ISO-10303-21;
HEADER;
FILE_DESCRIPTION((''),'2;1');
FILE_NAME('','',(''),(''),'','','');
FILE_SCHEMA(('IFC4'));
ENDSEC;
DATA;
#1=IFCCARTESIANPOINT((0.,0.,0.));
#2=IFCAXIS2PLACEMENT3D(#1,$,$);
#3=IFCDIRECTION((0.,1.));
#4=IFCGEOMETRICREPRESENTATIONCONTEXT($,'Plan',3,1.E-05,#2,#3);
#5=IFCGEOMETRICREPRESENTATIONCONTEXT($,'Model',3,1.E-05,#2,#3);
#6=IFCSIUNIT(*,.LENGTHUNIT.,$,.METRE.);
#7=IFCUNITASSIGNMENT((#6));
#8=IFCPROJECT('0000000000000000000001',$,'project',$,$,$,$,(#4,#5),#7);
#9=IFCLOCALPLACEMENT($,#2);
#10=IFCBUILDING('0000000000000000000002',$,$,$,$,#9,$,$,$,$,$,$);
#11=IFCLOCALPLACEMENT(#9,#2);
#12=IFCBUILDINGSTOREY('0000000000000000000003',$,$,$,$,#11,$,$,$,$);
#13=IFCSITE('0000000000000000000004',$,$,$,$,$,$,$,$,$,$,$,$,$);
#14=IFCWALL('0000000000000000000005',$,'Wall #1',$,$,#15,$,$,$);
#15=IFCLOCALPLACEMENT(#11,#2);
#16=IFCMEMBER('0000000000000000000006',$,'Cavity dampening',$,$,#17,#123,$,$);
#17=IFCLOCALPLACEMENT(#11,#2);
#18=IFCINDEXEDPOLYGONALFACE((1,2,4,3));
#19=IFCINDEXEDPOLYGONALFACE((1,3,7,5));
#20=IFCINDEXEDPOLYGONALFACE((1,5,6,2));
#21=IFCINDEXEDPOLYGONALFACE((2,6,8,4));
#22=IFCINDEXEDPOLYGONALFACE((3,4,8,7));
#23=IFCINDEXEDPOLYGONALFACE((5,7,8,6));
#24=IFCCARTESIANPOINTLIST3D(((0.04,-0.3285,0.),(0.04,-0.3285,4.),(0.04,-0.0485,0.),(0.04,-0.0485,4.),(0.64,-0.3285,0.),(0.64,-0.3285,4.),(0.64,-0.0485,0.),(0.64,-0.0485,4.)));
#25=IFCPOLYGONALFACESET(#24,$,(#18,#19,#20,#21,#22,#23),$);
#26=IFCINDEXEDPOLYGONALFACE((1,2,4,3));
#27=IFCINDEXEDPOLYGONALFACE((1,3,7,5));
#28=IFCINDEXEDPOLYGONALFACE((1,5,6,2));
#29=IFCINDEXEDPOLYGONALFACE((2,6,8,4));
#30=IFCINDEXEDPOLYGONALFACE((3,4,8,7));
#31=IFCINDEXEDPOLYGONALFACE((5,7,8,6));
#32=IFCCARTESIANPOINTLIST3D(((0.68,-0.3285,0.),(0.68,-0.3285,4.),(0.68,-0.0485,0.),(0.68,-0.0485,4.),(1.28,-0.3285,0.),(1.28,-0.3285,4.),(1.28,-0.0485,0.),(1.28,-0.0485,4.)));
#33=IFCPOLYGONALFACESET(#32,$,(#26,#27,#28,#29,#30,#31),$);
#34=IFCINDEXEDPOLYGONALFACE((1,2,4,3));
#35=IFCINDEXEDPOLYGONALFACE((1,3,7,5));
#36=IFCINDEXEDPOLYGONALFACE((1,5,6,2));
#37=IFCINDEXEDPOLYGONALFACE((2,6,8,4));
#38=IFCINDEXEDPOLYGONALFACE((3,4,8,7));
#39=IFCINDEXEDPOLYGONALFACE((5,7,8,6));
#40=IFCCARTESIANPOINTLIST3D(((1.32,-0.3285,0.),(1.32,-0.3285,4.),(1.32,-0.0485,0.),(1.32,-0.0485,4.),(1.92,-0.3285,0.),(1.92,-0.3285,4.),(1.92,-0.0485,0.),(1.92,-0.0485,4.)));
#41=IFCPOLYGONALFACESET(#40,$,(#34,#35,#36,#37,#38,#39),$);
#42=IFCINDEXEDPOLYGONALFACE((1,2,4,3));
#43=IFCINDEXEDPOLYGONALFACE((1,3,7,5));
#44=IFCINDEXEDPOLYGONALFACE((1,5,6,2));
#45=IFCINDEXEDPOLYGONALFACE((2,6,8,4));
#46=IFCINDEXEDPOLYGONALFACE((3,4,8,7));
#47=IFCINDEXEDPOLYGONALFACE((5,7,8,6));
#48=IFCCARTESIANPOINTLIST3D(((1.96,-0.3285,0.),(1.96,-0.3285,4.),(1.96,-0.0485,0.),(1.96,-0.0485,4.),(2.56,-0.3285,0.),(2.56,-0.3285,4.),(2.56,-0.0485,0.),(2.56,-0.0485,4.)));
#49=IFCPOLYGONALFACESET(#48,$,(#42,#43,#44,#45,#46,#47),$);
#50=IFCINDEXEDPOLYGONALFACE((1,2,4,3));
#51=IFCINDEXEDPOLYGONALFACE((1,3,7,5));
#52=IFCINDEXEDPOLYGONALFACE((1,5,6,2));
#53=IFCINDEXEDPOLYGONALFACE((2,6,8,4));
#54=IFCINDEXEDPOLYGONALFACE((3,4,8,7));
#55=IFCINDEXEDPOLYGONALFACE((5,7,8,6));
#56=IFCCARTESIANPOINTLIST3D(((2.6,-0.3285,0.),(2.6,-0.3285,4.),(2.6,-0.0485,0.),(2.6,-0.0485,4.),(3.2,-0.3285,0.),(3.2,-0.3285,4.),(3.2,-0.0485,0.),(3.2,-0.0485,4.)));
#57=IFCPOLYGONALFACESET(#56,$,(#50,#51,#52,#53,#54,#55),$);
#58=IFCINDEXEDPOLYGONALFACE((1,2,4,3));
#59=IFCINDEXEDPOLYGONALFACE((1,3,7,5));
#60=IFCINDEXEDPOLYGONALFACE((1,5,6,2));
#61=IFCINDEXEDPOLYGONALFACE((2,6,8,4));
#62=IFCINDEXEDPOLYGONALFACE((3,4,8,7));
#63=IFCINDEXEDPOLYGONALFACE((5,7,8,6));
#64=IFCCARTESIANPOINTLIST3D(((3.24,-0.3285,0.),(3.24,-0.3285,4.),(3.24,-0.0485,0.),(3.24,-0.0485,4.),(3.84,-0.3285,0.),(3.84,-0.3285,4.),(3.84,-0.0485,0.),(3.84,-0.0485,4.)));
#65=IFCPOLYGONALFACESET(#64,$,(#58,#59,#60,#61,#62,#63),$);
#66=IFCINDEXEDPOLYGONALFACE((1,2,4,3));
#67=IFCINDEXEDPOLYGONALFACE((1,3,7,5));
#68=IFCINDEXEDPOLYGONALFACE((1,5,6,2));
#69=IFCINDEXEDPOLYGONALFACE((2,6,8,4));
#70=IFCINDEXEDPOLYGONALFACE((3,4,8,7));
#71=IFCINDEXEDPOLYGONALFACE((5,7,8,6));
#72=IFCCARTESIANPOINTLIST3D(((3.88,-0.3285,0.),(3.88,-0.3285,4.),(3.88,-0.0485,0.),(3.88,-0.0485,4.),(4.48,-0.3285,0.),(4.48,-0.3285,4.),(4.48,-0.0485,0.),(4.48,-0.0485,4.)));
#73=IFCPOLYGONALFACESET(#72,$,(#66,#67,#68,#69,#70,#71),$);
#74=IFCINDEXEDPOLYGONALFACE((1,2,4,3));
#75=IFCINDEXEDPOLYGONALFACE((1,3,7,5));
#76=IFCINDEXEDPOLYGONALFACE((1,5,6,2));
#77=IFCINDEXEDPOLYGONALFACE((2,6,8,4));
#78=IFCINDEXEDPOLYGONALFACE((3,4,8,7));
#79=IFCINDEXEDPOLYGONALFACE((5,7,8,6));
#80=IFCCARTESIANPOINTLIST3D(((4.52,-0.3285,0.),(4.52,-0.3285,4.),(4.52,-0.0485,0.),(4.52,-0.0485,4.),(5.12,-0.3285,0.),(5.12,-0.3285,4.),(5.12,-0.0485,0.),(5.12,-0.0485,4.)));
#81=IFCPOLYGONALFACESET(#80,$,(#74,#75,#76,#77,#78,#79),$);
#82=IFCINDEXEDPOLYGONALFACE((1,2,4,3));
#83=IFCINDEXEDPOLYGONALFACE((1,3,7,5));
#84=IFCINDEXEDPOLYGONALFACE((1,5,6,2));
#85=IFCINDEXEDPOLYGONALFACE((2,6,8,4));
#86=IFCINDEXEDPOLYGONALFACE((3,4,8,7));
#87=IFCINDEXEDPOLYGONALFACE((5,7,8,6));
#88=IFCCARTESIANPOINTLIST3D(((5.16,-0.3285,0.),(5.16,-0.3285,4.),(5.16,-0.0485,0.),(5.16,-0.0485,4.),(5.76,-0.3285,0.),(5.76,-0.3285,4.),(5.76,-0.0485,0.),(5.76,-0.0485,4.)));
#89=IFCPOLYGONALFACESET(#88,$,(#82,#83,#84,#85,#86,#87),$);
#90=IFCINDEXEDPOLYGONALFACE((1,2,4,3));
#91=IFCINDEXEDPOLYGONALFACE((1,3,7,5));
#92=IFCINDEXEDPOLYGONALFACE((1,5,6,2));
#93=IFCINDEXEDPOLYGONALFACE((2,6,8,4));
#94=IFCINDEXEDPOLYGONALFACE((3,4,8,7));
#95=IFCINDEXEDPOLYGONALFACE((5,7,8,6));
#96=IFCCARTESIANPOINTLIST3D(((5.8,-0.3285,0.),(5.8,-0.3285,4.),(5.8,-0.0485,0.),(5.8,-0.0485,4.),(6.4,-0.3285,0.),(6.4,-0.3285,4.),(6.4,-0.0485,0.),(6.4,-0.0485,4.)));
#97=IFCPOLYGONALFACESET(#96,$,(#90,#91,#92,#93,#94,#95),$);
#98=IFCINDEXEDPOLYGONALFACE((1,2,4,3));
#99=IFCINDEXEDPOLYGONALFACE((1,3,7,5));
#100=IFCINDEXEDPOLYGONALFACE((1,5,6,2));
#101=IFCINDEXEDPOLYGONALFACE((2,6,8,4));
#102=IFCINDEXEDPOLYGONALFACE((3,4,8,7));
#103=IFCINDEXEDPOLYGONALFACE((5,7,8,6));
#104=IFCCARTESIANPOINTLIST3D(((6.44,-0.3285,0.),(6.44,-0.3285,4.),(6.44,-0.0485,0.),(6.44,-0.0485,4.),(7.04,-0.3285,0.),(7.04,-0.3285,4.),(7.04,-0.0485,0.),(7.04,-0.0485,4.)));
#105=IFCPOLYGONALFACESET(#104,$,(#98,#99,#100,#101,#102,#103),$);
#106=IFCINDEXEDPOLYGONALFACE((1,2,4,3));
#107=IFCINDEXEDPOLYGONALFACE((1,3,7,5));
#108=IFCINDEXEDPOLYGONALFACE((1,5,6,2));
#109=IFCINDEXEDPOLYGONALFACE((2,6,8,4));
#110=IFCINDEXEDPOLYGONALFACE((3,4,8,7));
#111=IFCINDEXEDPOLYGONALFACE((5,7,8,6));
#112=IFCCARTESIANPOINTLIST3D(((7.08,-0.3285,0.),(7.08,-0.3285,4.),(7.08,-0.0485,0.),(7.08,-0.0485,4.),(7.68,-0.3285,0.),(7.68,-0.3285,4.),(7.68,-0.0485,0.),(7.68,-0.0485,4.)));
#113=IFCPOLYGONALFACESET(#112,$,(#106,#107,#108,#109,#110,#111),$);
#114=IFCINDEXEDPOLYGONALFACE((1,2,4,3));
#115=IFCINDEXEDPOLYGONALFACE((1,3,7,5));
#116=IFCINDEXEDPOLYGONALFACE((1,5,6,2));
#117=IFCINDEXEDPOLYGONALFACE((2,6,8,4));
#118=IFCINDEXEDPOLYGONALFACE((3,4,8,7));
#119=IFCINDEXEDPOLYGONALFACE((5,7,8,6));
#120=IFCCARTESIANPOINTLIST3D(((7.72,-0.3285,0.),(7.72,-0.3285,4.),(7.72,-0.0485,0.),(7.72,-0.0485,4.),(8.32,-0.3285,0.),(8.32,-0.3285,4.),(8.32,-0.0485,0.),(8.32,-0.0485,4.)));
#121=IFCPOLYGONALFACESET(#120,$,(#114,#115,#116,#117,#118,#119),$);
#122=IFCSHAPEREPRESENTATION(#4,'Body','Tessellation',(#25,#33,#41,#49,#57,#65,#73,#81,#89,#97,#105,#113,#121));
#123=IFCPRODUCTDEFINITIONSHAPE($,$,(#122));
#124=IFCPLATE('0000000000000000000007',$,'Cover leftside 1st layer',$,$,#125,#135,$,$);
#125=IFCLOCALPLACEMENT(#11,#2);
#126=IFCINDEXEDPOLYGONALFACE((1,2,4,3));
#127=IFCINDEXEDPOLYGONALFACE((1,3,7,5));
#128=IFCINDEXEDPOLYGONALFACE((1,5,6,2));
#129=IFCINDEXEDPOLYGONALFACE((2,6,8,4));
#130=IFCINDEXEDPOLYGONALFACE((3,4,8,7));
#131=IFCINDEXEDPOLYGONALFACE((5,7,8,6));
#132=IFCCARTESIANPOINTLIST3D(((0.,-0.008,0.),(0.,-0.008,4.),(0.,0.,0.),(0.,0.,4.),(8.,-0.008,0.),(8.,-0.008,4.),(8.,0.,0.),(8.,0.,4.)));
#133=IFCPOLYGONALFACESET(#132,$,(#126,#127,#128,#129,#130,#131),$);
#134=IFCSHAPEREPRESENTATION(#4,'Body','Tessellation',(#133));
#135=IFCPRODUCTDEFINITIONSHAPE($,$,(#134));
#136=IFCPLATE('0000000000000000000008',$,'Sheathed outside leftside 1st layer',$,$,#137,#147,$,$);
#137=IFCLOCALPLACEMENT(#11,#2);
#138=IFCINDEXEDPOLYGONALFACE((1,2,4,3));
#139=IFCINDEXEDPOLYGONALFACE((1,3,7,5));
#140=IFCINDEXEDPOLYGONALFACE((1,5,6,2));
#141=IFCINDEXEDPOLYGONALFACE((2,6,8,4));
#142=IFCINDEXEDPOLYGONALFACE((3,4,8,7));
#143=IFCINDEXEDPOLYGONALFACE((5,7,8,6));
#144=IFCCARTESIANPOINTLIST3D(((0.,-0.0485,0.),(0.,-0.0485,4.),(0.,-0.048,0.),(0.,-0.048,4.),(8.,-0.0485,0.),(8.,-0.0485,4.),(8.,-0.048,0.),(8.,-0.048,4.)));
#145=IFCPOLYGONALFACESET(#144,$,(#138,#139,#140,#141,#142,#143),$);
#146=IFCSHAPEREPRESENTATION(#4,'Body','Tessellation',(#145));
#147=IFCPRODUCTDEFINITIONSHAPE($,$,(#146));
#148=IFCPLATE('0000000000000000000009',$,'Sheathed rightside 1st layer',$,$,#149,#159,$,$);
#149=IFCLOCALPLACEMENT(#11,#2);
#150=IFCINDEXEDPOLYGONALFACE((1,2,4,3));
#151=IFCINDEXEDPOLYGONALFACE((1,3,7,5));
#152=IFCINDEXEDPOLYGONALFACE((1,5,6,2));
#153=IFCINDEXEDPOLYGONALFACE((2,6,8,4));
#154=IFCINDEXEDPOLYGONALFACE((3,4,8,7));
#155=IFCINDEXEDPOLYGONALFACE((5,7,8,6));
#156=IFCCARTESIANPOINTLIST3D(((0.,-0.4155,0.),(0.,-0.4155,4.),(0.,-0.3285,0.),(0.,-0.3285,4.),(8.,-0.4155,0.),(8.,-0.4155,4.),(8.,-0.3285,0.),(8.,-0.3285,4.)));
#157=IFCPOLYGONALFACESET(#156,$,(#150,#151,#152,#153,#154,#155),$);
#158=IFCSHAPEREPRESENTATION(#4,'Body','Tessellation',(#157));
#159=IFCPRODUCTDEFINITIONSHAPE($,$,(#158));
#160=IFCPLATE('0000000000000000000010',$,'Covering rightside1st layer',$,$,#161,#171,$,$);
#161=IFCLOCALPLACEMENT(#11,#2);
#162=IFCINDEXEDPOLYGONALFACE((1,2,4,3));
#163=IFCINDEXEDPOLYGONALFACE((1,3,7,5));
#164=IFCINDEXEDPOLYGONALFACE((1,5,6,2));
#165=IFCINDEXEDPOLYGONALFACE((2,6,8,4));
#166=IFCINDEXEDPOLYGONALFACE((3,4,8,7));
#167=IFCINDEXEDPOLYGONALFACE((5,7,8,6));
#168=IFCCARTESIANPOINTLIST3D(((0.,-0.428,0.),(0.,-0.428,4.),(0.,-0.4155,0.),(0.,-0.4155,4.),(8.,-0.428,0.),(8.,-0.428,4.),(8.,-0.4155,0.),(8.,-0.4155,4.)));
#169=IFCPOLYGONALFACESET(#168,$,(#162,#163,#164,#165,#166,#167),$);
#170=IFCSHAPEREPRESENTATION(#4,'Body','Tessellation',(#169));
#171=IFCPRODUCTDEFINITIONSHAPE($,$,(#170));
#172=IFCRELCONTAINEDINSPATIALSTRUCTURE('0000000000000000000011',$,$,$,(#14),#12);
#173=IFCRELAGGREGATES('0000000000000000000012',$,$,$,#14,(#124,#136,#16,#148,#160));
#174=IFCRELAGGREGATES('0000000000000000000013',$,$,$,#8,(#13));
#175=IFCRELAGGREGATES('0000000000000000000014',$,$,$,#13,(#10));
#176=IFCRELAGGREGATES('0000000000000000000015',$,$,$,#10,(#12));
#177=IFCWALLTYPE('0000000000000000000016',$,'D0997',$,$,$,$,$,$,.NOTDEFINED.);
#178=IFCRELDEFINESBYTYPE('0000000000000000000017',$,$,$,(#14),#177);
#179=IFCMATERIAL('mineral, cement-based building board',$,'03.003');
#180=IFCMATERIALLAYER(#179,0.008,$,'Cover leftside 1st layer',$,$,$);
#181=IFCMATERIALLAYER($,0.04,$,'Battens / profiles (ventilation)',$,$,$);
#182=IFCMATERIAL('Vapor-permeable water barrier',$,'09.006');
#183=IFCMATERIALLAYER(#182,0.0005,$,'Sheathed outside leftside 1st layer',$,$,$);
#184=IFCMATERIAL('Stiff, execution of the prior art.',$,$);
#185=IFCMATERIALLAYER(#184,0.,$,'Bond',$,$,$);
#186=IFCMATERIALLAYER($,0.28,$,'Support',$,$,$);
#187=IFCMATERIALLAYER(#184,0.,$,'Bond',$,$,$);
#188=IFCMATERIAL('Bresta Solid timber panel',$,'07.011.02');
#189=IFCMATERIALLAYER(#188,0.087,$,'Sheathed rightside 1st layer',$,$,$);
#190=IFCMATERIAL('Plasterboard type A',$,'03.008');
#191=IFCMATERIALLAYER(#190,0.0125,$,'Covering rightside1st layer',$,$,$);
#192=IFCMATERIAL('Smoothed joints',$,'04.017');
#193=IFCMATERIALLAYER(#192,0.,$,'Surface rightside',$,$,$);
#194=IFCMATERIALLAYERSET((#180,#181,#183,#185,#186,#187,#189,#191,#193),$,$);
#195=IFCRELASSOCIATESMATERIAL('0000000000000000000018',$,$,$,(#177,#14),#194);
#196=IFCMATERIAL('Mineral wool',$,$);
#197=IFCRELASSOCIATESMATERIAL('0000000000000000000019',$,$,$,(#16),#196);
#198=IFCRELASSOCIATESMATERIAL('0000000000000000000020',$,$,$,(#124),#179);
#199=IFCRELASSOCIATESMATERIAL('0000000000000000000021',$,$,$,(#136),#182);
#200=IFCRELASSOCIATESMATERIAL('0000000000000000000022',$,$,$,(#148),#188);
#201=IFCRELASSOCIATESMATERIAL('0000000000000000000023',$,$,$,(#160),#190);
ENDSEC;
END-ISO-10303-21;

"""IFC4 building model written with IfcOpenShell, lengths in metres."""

from ifc_helpers import new_model, si_unit, direction, frame, frame_2d, origin, origin_with_axes, place, context, project, spatial, rectangle, extrude, material, layer, layer_set, type_object, element, aggregate, save


model = new_model("IFC4")

# Units and contexts
plan_context = context("Plan", 3, precision=1e-05, world=origin(), true_north=direction((0.0, 1.0)))
model_context = context("Model", 3, precision=1e-05, world=origin(), true_north=direction((0.0, 1.0)))
ifc_project = project(units=[si_unit("LENGTHUNIT", "METRE")], contexts=[plan_context, model_context])

# Site, building, storey
site = spatial("IfcSite", under=ifc_project)
building_placement = place(None, origin())
building = spatial("IfcBuilding", under=site, at=building_placement)
storey_placement = place(building_placement, origin())
storey = spatial("IfcBuildingStorey", under=building, at=storey_placement)

# Wall, member, plates
ifc_material_1 = material(Name="mineral, cement-based building board", Category="03.003")
ifc_layer_1 = layer(ifc_material_1, 0.008, Name="Cover leftside 1st layer")
ifc_layer_2 = layer(None, 0.04, Name="Battens / profiles (ventilation)")
ifc_material_2 = material(Name="Vapor-permeable water barrier", Category="09.006")
ifc_layer_3 = layer(ifc_material_2, 0.0005, Name="Sheathed outside leftside 1st layer")
ifc_material_3 = material(Name="Stiff, execution of the prior art.")
ifc_layer_4 = layer(ifc_material_3, 0.0, Name="Bond")
ifc_layer_5 = layer(None, 0.28, Name="Support")
ifc_layer_6 = layer(ifc_material_3, 0.0, Name="Bond")
ifc_material_4 = material(Name="Bresta Solid timber panel", Category="07.011.02")
ifc_layer_7 = layer(ifc_material_4, 0.087, Name="Sheathed rightside 1st layer")
ifc_material_5 = material(Name="Plasterboard type A", Category="03.008")
ifc_layer_8 = layer(ifc_material_5, 0.0125, Name="Covering rightside1st layer")
ifc_material_6 = material(Name="Smoothed joints", Category="04.017")
ifc_layer_9 = layer(ifc_material_6, 0.0, Name="Surface rightside")
ifc_layer_set = layer_set([ifc_layer_1, ifc_layer_2, ifc_layer_3, ifc_layer_4, ifc_layer_5, ifc_layer_6, ifc_layer_7, ifc_layer_8, ifc_layer_9])
wall_type = type_object("IfcWallType", Name="D0997", PredefinedType="NOTDEFINED", material=ifc_layer_set)
wall_placement = place(None, frame((0.0, 0.0, 0.0), z_axis=(0.0, -1.0, 0.0), x_axis=(1.0, 0.0, 0.0)))
wall = element("IfcWall", 1, at=wall_placement, inside=storey, type_object=wall_type, material=ifc_layer_set, Name="Wall #1")
ifc_material_7 = material(Name="Mineral wool")
member_1_placement = place(wall_placement, origin())
member_1 = element("IfcMember", 2, at=member_1_placement, material=ifc_material_7, Name="Cavity dampening", context=plan_context, shape_type="SweptSolid", body=[
    extrude(rectangle(XDim=0.6, YDim=0.28, at=frame_2d((0.3, 0.14), x_axis=(1.0, 0.0))), frame((0.04, 4.0, 0.0485), z_axis=(0.0, -1.0, 0.0), x_axis=(1.0, 0.0, 0.0)), (0.0, 0.0, 1.0), 4.0),
    extrude(rectangle(XDim=0.6, YDim=0.28, at=frame_2d((0.3, 0.14), x_axis=(1.0, 0.0))), frame((0.68, 4.0, 0.0485), z_axis=(0.0, -1.0, 0.0), x_axis=(1.0, 0.0, 0.0)), (0.0, 0.0, 1.0), 4.0),
    extrude(rectangle(XDim=0.6, YDim=0.28, at=frame_2d((0.3, 0.14), x_axis=(1.0, 0.0))), frame((1.32, 4.0, 0.0485), z_axis=(0.0, -1.0, 0.0), x_axis=(1.0, 0.0, 0.0)), (0.0, 0.0, 1.0), 4.0),
    extrude(rectangle(XDim=0.6, YDim=0.28, at=frame_2d((0.3, 0.14), x_axis=(1.0, 0.0))), frame((1.96, 4.0, 0.0485), z_axis=(0.0, -1.0, 0.0), x_axis=(1.0, 0.0, 0.0)), (0.0, 0.0, 1.0), 4.0),
    extrude(rectangle(XDim=0.6, YDim=0.28, at=frame_2d((0.3, 0.14), x_axis=(1.0, 0.0))), frame((2.6, 4.0, 0.0485), z_axis=(0.0, -1.0, 0.0), x_axis=(1.0, 0.0, 0.0)), (0.0, 0.0, 1.0), 4.0),
    extrude(rectangle(XDim=0.6, YDim=0.28, at=frame_2d((0.3, 0.14), x_axis=(1.0, 0.0))), frame((3.24, 4.0, 0.0485), z_axis=(0.0, -1.0, 0.0), x_axis=(1.0, 0.0, 0.0)), (0.0, 0.0, 1.0), 4.0),
    extrude(rectangle(XDim=0.6, YDim=0.28, at=frame_2d((0.3, 0.14), x_axis=(1.0, 0.0))), frame((3.88, 4.0, 0.0485), z_axis=(0.0, -1.0, 0.0), x_axis=(1.0, 0.0, 0.0)), (0.0, 0.0, 1.0), 4.0),
    extrude(rectangle(XDim=0.6, YDim=0.28, at=frame_2d((0.3, 0.14), x_axis=(1.0, 0.0))), frame((4.52, 4.0, 0.0485), z_axis=(0.0, -1.0, 0.0), x_axis=(1.0, 0.0, 0.0)), (0.0, 0.0, 1.0), 4.0),
    extrude(rectangle(XDim=0.6, YDim=0.28, at=frame_2d((0.3, 0.14), x_axis=(1.0, 0.0))), frame((5.16, 4.0, 0.0485), z_axis=(0.0, -1.0, 0.0), x_axis=(1.0, 0.0, 0.0)), (0.0, 0.0, 1.0), 4.0),
    extrude(rectangle(XDim=0.6, YDim=0.28, at=frame_2d((0.3, 0.14), x_axis=(1.0, 0.0))), frame((5.8, 4.0, 0.0485), z_axis=(0.0, -1.0, 0.0), x_axis=(1.0, 0.0, 0.0)), (0.0, 0.0, 1.0), 4.0),
    extrude(rectangle(XDim=0.6, YDim=0.28, at=frame_2d((0.3, 0.14), x_axis=(1.0, 0.0))), frame((6.44, 4.0, 0.0485), z_axis=(0.0, -1.0, 0.0), x_axis=(1.0, 0.0, 0.0)), (0.0, 0.0, 1.0), 4.0),
    extrude(rectangle(XDim=0.6, YDim=0.28, at=frame_2d((0.3, 0.14), x_axis=(1.0, 0.0))), frame((7.08, 4.0, 0.0485), z_axis=(0.0, -1.0, 0.0), x_axis=(1.0, 0.0, 0.0)), (0.0, 0.0, 1.0), 4.0),
    extrude(rectangle(XDim=0.6, YDim=0.28, at=frame_2d((0.3, 0.14), x_axis=(1.0, 0.0))), frame((7.72, 4.0, 0.0485), z_axis=(0.0, -1.0, 0.0), x_axis=(1.0, 0.0, 0.0)), (0.0, 0.0, 1.0), 4.0),
])
plate_1_placement = place(wall_placement, origin())
plate_1 = element("IfcPlate", 3, at=plate_1_placement, material=ifc_material_1, Name="Cover leftside 1st layer", context=plan_context, shape_type="SweptSolid", body=[
    extrude(rectangle(XDim=8.0, YDim=4.0, at=frame_2d((4.0, 2.0), x_axis=(1.0, 0.0))), origin_with_axes(), (0.0, 0.0, 1.0), 0.008),
])
plate_2_placement = place(wall_placement, origin())
plate_2 = element("IfcPlate", 4, at=plate_2_placement, material=ifc_material_2, Name="Sheathed outside leftside 1st layer", context=plan_context, shape_type="SweptSolid", body=[
    extrude(rectangle(XDim=8.0, YDim=4.0, at=frame_2d((4.0, 2.0), x_axis=(1.0, 0.0))), frame((0.0, 0.0, 0.048), z_axis=(0.0, 0.0, 1.0), x_axis=(1.0, 0.0, 0.0)), (0.0, 0.0, 1.0), 0.0005),
])
plate_3_placement = place(wall_placement, origin())
plate_3 = element("IfcPlate", 5, at=plate_3_placement, material=ifc_material_4, Name="Sheathed rightside 1st layer", context=plan_context, shape_type="SweptSolid", body=[
    extrude(rectangle(XDim=8.0, YDim=4.0, at=frame_2d((4.0, 2.0), x_axis=(1.0, 0.0))), frame((0.0, 0.0, 0.3285), z_axis=(0.0, 0.0, 1.0), x_axis=(1.0, 0.0, 0.0)), (0.0, 0.0, 1.0), 0.087),
])
plate_4_placement = place(wall_placement, origin())
plate_4 = element("IfcPlate", 6, at=plate_4_placement, material=ifc_material_5, Name="Covering rightside1st layer", context=plan_context, shape_type="SweptSolid", body=[
    extrude(rectangle(XDim=8.0, YDim=4.0, at=frame_2d((4.0, 2.0), x_axis=(1.0, 0.0))), frame((0.0, 0.0, 0.4155), z_axis=(0.0, 0.0, 1.0), x_axis=(1.0, 0.0, 0.0)), (0.0, 0.0, 1.0), 0.0125),
])
aggregate(wall, [plate_1, plate_2, member_1, plate_3, plate_4])

save(model, "model.ifc")
